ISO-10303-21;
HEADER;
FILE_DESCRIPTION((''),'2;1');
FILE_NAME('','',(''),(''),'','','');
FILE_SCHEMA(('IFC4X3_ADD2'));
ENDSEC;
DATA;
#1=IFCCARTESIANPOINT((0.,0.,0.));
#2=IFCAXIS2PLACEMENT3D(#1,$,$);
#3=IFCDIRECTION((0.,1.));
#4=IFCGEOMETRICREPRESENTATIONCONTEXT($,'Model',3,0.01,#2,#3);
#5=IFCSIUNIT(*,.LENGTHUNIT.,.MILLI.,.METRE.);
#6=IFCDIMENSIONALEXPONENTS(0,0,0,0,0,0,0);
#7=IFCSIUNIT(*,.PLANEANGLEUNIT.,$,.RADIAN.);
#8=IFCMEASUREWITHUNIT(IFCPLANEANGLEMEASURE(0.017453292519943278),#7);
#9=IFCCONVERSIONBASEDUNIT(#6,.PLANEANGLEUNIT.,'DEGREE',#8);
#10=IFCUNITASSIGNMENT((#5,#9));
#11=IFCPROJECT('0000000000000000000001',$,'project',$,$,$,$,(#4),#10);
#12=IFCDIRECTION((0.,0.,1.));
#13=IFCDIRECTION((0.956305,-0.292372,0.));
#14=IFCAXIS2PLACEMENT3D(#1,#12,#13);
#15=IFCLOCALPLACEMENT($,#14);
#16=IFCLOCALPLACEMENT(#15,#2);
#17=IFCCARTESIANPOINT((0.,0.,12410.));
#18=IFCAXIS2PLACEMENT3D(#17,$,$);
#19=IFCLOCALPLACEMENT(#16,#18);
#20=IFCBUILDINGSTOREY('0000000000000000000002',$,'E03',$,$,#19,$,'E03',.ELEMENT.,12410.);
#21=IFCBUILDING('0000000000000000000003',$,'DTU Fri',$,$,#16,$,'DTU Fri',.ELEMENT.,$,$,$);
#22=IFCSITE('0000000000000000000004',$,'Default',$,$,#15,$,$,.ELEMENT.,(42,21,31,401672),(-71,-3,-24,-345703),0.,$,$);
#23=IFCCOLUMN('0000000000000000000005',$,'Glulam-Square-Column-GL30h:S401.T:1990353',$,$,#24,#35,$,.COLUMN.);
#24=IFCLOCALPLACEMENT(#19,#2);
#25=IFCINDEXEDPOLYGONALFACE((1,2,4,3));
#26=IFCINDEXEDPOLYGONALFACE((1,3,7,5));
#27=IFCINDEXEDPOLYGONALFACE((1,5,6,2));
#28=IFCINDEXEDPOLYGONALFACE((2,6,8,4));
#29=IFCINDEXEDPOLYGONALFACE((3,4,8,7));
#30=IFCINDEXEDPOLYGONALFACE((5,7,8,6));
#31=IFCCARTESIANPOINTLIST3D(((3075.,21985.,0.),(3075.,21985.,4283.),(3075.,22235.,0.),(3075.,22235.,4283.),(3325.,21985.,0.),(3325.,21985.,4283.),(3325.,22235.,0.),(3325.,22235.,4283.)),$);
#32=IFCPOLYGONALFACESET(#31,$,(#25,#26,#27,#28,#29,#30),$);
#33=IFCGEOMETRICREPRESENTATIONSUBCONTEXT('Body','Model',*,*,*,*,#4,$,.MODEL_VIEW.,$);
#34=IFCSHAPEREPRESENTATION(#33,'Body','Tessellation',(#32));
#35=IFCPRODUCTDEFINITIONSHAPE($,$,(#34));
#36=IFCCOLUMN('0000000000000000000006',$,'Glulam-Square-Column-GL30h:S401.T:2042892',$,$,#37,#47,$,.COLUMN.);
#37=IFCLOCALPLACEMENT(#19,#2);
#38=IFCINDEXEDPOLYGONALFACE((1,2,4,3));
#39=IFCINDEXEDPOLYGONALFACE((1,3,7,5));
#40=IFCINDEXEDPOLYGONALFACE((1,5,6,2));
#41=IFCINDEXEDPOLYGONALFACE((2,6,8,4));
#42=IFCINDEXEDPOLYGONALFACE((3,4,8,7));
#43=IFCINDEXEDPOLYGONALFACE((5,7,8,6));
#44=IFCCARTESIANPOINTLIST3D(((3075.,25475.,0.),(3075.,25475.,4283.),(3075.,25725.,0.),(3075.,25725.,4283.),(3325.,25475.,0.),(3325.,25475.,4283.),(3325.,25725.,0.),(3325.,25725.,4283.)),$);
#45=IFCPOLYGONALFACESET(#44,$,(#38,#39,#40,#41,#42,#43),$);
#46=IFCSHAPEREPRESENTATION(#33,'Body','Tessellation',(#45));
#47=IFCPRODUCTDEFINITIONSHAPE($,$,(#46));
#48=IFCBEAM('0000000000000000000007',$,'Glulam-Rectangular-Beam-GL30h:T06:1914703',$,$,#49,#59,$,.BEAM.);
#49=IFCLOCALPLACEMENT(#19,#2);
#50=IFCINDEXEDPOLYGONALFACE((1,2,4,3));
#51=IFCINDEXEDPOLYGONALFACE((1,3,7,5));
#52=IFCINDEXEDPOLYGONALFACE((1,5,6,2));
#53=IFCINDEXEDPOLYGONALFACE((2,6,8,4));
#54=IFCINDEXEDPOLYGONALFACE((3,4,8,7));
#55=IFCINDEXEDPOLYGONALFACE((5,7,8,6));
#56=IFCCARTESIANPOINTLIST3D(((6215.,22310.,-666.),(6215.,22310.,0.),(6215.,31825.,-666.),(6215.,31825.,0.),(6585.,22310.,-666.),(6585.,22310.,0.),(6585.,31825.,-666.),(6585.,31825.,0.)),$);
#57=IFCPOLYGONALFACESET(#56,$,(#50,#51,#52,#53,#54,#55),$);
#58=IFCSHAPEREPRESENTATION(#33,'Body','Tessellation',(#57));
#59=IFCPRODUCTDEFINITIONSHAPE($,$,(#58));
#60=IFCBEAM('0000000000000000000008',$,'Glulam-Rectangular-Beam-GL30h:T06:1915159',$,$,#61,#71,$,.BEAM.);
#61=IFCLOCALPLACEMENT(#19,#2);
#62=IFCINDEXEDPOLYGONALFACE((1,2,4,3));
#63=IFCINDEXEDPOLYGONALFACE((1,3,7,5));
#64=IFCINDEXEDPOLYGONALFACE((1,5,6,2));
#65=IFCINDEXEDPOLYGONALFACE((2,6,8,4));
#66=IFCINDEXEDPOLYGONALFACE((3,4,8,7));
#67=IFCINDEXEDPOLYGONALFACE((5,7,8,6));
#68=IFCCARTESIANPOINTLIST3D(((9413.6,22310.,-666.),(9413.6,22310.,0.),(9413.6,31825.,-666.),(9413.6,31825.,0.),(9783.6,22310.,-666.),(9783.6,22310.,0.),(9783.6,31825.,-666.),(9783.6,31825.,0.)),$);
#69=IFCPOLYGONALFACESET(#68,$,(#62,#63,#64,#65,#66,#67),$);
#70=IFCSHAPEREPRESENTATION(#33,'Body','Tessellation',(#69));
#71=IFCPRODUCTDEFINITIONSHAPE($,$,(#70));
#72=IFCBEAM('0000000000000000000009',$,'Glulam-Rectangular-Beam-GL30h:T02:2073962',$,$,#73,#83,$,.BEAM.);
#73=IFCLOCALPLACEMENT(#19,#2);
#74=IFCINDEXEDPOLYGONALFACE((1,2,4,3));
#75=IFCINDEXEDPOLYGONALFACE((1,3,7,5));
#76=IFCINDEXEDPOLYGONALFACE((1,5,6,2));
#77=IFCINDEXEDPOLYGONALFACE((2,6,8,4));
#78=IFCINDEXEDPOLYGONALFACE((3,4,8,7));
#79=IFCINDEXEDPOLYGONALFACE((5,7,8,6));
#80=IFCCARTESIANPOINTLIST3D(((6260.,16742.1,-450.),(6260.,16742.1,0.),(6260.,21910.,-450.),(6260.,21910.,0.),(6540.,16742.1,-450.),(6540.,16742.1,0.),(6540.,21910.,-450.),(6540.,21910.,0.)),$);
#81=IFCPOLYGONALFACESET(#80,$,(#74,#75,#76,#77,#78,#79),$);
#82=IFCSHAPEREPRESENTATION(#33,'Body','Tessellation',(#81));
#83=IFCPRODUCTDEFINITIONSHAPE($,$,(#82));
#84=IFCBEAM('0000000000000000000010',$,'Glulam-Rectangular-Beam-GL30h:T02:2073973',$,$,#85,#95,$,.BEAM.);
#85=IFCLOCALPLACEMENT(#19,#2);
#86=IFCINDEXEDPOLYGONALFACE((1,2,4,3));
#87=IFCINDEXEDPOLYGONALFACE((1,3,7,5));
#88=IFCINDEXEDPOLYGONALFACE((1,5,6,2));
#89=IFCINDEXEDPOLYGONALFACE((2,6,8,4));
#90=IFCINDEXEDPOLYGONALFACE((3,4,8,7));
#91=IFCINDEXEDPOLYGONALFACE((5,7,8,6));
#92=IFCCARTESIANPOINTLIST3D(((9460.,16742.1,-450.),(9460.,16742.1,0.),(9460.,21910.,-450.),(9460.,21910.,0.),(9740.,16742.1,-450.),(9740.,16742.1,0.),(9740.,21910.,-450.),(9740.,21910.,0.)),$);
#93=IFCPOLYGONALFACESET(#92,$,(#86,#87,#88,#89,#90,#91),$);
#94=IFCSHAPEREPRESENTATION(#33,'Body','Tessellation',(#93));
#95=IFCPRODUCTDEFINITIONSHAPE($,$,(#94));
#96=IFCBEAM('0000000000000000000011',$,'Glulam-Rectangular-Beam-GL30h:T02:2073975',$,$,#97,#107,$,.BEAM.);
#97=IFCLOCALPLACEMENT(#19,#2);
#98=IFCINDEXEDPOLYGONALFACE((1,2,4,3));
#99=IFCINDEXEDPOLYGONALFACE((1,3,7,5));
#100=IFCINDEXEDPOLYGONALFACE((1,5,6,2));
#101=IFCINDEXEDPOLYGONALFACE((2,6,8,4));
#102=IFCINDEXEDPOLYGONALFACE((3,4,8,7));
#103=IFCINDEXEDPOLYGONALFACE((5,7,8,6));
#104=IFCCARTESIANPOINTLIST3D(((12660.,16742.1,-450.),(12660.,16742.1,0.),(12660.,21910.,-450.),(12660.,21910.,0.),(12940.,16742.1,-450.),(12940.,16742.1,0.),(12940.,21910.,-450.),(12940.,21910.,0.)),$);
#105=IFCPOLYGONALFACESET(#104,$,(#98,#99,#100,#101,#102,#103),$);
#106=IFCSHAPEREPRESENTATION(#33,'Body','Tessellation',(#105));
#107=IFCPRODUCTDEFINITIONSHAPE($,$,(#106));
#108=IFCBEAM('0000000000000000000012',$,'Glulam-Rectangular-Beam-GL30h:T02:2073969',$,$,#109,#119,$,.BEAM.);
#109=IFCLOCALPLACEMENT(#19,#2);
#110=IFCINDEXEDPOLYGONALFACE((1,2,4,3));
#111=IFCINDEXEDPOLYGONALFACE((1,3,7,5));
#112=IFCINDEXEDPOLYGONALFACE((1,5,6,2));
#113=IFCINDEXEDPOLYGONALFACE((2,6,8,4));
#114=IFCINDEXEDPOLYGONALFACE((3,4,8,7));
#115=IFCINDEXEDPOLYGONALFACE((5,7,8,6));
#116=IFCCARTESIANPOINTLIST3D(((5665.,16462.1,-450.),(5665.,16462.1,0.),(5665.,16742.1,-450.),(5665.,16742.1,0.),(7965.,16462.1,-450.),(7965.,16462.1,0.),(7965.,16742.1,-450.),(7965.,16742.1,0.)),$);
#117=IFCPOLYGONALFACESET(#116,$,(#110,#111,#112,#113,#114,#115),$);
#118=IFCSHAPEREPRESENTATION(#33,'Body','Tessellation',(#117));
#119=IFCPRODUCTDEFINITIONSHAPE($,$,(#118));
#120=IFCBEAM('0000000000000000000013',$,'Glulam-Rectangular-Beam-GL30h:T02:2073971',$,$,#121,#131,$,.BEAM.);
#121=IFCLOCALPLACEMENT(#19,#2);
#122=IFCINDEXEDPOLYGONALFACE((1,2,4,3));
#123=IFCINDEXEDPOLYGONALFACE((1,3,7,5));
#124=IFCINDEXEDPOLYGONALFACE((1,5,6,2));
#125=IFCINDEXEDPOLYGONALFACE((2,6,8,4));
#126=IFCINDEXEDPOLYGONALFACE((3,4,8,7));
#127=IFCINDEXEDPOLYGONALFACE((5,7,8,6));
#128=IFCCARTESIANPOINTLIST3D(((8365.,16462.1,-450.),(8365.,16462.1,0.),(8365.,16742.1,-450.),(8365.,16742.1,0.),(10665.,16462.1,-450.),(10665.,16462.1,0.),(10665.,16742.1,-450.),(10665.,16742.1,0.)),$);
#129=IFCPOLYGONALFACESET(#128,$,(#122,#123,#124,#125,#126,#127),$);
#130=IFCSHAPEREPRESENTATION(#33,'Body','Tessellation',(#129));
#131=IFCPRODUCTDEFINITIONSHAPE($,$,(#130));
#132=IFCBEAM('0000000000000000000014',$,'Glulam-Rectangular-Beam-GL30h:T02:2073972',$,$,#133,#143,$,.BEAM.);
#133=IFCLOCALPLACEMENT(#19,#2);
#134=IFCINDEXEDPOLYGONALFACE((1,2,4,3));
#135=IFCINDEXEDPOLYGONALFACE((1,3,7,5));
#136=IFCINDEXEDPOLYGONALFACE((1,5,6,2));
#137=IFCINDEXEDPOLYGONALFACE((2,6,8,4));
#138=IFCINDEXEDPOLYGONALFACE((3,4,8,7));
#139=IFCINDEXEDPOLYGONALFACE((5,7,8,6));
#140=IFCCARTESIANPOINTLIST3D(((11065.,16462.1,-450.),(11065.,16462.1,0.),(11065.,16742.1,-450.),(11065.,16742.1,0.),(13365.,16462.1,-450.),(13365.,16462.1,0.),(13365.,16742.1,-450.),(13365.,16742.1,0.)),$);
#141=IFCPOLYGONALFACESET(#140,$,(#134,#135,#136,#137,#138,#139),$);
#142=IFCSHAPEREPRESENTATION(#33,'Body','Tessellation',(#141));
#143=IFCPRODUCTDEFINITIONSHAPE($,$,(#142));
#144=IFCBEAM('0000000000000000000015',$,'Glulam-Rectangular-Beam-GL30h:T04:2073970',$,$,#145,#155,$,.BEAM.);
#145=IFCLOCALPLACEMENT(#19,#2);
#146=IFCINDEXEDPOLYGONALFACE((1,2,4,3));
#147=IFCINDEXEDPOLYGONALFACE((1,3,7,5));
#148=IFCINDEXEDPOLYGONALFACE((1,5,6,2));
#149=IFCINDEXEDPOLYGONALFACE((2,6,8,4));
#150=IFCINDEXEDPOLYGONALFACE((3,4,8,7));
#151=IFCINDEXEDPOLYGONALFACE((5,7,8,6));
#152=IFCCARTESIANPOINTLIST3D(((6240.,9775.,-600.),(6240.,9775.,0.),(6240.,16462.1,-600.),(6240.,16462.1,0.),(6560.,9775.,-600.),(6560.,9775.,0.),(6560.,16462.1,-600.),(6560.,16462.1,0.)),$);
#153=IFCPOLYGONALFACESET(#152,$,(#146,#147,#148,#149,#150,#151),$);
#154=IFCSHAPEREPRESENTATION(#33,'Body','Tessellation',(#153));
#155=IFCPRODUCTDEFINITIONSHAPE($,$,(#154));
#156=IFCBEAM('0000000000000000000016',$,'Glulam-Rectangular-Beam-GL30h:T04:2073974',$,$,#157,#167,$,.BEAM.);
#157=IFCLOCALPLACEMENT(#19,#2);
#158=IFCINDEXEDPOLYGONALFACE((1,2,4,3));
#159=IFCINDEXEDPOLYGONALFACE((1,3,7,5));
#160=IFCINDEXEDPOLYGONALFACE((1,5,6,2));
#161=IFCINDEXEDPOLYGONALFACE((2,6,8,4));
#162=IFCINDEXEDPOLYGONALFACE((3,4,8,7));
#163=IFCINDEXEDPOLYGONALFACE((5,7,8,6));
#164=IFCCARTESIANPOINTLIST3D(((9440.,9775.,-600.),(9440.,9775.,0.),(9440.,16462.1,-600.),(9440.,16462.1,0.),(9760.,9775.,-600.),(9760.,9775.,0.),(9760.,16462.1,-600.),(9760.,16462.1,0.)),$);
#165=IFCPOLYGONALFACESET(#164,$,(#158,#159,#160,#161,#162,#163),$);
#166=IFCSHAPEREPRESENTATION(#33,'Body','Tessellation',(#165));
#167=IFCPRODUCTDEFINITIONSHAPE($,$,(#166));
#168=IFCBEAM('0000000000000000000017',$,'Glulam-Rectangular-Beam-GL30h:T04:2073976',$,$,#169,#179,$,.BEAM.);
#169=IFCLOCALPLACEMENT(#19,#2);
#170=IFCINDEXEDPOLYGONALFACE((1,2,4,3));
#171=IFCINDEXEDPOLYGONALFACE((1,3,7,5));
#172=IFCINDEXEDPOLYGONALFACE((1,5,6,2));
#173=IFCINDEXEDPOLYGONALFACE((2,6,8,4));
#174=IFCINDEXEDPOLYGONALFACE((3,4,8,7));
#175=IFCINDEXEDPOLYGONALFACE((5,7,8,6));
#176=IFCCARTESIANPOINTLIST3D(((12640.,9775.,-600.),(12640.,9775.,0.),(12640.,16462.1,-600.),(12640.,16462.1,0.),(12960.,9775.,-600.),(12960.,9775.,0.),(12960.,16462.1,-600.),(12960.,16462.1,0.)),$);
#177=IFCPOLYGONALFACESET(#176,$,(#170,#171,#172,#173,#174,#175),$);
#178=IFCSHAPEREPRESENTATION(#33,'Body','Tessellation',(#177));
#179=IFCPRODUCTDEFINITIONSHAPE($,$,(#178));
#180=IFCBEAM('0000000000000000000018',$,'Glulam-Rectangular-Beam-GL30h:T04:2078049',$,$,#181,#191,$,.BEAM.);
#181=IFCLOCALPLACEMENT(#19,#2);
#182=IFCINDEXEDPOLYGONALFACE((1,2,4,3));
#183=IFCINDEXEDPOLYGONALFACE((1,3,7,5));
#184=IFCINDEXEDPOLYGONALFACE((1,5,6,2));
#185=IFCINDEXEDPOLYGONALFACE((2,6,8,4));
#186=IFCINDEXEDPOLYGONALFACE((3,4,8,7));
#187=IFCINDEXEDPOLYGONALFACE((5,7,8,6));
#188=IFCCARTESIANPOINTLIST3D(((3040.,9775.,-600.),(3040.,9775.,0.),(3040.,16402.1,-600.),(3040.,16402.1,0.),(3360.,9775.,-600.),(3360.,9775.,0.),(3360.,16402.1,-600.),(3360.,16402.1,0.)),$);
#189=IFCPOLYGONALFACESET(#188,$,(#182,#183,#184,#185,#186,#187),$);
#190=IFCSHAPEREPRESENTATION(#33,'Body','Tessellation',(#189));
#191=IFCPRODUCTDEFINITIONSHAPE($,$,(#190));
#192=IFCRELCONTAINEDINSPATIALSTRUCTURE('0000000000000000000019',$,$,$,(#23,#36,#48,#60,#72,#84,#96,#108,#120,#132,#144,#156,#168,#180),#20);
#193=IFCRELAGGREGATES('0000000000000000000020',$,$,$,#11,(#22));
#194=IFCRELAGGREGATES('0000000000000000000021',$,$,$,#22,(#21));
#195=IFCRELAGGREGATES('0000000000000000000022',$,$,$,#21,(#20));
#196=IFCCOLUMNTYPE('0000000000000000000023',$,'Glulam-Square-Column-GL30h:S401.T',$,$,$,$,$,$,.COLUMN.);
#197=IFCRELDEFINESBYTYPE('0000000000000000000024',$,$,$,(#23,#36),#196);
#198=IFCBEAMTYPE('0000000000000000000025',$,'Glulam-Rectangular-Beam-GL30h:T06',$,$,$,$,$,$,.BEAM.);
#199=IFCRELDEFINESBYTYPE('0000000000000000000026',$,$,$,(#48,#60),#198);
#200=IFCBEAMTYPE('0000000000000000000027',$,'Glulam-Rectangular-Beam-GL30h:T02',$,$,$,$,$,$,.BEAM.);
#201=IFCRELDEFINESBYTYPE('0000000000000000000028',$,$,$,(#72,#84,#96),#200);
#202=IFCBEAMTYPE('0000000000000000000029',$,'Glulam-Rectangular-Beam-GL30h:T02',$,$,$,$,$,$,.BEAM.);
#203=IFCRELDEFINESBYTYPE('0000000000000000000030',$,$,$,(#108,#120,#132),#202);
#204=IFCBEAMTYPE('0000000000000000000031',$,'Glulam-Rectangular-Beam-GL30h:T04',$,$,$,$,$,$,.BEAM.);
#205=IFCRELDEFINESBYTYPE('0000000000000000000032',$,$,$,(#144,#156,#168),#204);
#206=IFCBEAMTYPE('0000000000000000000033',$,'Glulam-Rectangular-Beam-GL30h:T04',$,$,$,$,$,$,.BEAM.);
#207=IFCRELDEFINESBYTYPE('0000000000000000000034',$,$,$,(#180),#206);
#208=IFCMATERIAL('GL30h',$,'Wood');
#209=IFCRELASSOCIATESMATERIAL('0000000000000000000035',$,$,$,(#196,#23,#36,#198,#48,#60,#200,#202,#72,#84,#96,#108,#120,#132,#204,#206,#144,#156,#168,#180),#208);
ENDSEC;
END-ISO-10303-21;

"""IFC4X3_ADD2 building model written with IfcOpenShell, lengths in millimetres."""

from ifc_helpers import new_model, entity, si_unit, converted_unit, direction, frame, origin, origin_2d_with_axis, place, context, subcontext, project, spatial, rectangle, extrude, source, transform, mapped, material, material_profile, profile_set, profile_usage, type_object, type_shapes, element, save


model = new_model("IFC4X3_ADD2")

# Units and contexts
model_context = context("Model", 3, precision=0.01, world=origin(), true_north=direction((0.0, 1.0)))
body_context = subcontext(model_context, "Body", "Model", "MODEL_VIEW")
ifc_project = project(units=[si_unit("LENGTHUNIT", "METRE", prefix="MILLI"), converted_unit("PLANEANGLEUNIT", "DEGREE", entity("IfcPlaneAngleMeasure", 0.017453292519943278), si_unit("PLANEANGLEUNIT", "RADIAN"), dimensions=[0, 0, 0, 0, 0, 0, 0])], contexts=[model_context])

# Site, building, storey
site_placement = place(None, frame((0.0, 0.0, 0.0), z_axis=(0.0, 0.0, 1.0), x_axis=(0.956305, -0.292372, 0.0)))
site = spatial("IfcSite", under=ifc_project, at=site_placement, Name="Default", CompositionType="ELEMENT", RefLatitude=(42, 21, 31, 401672), RefLongitude=(-71, -3, -24, -345703), RefElevation=0.0)
building_placement = place(site_placement, origin())
building = spatial("IfcBuilding", under=site, at=building_placement, Name="DTU Fri", LongName="DTU Fri", CompositionType="ELEMENT")
storey_placement = place(building_placement, frame((0.0, 0.0, 12410.0)))
storey = spatial("IfcBuildingStorey", under=building, at=storey_placement, Name="E03", LongName="E03", CompositionType="ELEMENT", Elevation=12410.0)

# Columns
ifc_material = material(Name="GL30h", Category="Wood")
ifc_material_profile_1 = material_profile(ifc_material, rectangle(XDim=250.0, YDim=250.0, at=origin_2d_with_axis()), Name="S401.T")
ifc_profile_set_1 = profile_set([ifc_material_profile_1], Name="S401.T")
ifc_profile_usage_1 = profile_usage(ifc_profile_set_1)
column_type = type_object("IfcColumnType", Name="Glulam-Square-Column-GL30h:S401.T", PredefinedType="COLUMN", material=ifc_profile_set_1)
shared_shape_1 = source(origin(), body_context, "Body", "SweptSolid", [
    extrude(rectangle(XDim=250.0, YDim=250.0, at=origin_2d_with_axis()), frame((0.0, 0.0, 12410.0), z_axis=(0.0, 0.0, 1.0), x_axis=(0.0, 1.0, 0.0)), (0.0, 0.0, 1.0), 4283.0),
])
type_shapes(column_type, [shared_shape_1])
for number, where, name in (
    (1, (3200.0, 22110.0, -12410.0), "Glulam-Square-Column-GL30h:S401.T:1990353"),
    (2, (3200.0, 25600.0, -12410.0), "Glulam-Square-Column-GL30h:S401.T:2042892"),
):
    element("IfcColumn", number, at=place(storey_placement, frame(where)), inside=storey, type_object=column_type, material=ifc_profile_usage_1, Name=name, PredefinedType="COLUMN", context=body_context, shape_type="MappedRepresentation", body=[
        mapped(shared_shape_1, transform((0.0, 0.0, 0.0), scale=1.0)),
    ])

# Beams
ifc_material_profile_2 = material_profile(ifc_material, rectangle(XDim=666.0, YDim=370.0, at=origin_2d_with_axis()), Name="T06")
ifc_profile_set_2 = profile_set([ifc_material_profile_2], Name="T06")
ifc_profile_usage_2 = profile_usage(ifc_profile_set_2, cardinal=8)
beam_type_1 = type_object("IfcBeamType", Name="Glulam-Rectangular-Beam-GL30h:T06", PredefinedType="BEAM", material=ifc_profile_set_2)
shared_shape_2 = source(origin(), body_context, "Body", "SweptSolid", [
    extrude(rectangle(XDim=666.0, YDim=370.0, at=origin_2d_with_axis()), frame((-4770.0, 0.0, 0.0), z_axis=(1.0, 0.0, 0.0), x_axis=(0.0, 0.0, -1.0)), (0.0, 0.0, 1.0), 9515.0),
])
type_shapes(beam_type_1, [shared_shape_2])
for number, where, z_axis, x_axis, name in (
    (3, (6400.0, 27055.0, -333.0), (0.0, 0.0, 1.0), (0.0, -1.0, 0.0), "Glulam-Rectangular-Beam-GL30h:T06:1914703"),
    (4, (9598.6, 27055.0, -333.0), (0.0, 0.0, 1.0), (0.0, -1.0, 0.0), "Glulam-Rectangular-Beam-GL30h:T06:1915159"),
):
    element("IfcBeam", number, at=place(storey_placement, frame(where, z_axis=z_axis, x_axis=x_axis)), inside=storey, type_object=beam_type_1, material=ifc_profile_usage_2, Name=name, PredefinedType="BEAM", context=body_context, shape_type="MappedRepresentation", body=[
        mapped(shared_shape_2, transform((0.0, 0.0, 0.0), scale=1.0)),
    ])
ifc_material_profile_3 = material_profile(ifc_material, rectangle(XDim=450.0, YDim=280.0, at=origin_2d_with_axis()), Name="T02")
ifc_profile_set_3 = profile_set([ifc_material_profile_3], Name="T02")
ifc_profile_usage_3 = profile_usage(ifc_profile_set_3, cardinal=8)
beam_type_2 = type_object("IfcBeamType", Name="Glulam-Rectangular-Beam-GL30h:T02", PredefinedType="BEAM", material=ifc_profile_set_3)
shared_shape_3 = source(origin(), body_context, "Body", "SweptSolid", [
    extrude(rectangle(XDim=450.0, YDim=280.0, at=origin_2d_with_axis()), frame((-2614.0, 0.0, 0.0), z_axis=(1.0, 0.0, 0.0), x_axis=(0.0, 0.0, -1.0)), (0.0, 0.0, 1.0), 5167.9),
])
type_shapes(beam_type_2, [shared_shape_3])
for number, where, z_axis, x_axis, name in (
    (5, (6400.0, 19356.0, -225.0), (0.0, 0.0, 1.0), (0.0, 1.0, 0.0), "Glulam-Rectangular-Beam-GL30h:T02:2073962"),
    (6, (9600.0, 19356.0, -225.0), (0.0, 0.0, 1.0), (0.0, 1.0, 0.0), "Glulam-Rectangular-Beam-GL30h:T02:2073973"),
    (7, (12800.0, 19356.0, -225.0), (0.0, 0.0, 1.0), (0.0, 1.0, 0.0), "Glulam-Rectangular-Beam-GL30h:T02:2073975"),
):
    element("IfcBeam", number, at=place(storey_placement, frame(where, z_axis=z_axis, x_axis=x_axis)), inside=storey, type_object=beam_type_2, material=ifc_profile_usage_3, Name=name, PredefinedType="BEAM", context=body_context, shape_type="MappedRepresentation", body=[
        mapped(shared_shape_3, transform((0.0, 0.0, 0.0), scale=1.0)),
    ])
beam_type_3 = type_object("IfcBeamType", Name="Glulam-Rectangular-Beam-GL30h:T02", PredefinedType="BEAM", material=ifc_profile_set_3)
shared_shape_4 = source(origin(), body_context, "Body", "SweptSolid", [
    extrude(rectangle(XDim=450.0, YDim=280.0, at=origin_2d_with_axis()), frame((-1150.0, 0.0, 0.0), z_axis=(1.0, 0.0, 0.0), x_axis=(0.0, 0.0, -1.0)), (0.0, 0.0, 1.0), 2300.0),
])
type_shapes(beam_type_3, [shared_shape_4])
for number, where, z_axis, x_axis, name in (
    (8, (6815.0, 16602.1, -225.0), (0.0, 0.0, 1.0), (-1.0, 0.0, 0.0), "Glulam-Rectangular-Beam-GL30h:T02:2073969"),
    (9, (9515.0, 16602.1, -225.0), (0.0, 0.0, 1.0), (-1.0, 0.0, 0.0), "Glulam-Rectangular-Beam-GL30h:T02:2073971"),
    (10, (12215.0, 16602.1, -225.0), (0.0, 0.0, 1.0), (-1.0, 0.0, 0.0), "Glulam-Rectangular-Beam-GL30h:T02:2073972"),
):
    element("IfcBeam", number, at=place(storey_placement, frame(where, z_axis=z_axis, x_axis=x_axis)), inside=storey, type_object=beam_type_3, material=ifc_profile_usage_3, Name=name, PredefinedType="BEAM", context=body_context, shape_type="MappedRepresentation", body=[
        mapped(shared_shape_4, transform((0.0, 0.0, 0.0), scale=1.0)),
    ])
ifc_material_profile_4 = material_profile(ifc_material, rectangle(XDim=600.0, YDim=320.0, at=origin_2d_with_axis()), Name="T04")
ifc_profile_set_4 = profile_set([ifc_material_profile_4], Name="T04")
ifc_profile_usage_4 = profile_usage(ifc_profile_set_4, cardinal=8)
beam_type_4 = type_object("IfcBeamType", Name="Glulam-Rectangular-Beam-GL30h:T04", PredefinedType="BEAM", material=ifc_profile_set_4)
shared_shape_5 = source(origin(), body_context, "Body", "SweptSolid", [
    extrude(rectangle(XDim=600.0, YDim=320.0, at=origin_2d_with_axis()), frame((-3326.0, 0.0, 0.0), z_axis=(1.0, 0.0, 0.0), x_axis=(0.0, 0.0, -1.0)), (0.0, 0.0, 1.0), 6687.1),
])
type_shapes(beam_type_4, [shared_shape_5])
for number, where, z_axis, x_axis, name in (
    (11, (6400.0, 13101.0, -300.0), (0.0, 0.0, 1.0), (0.0, 1.0, 0.0), "Glulam-Rectangular-Beam-GL30h:T04:2073970"),
    (12, (9600.0, 13101.0, -300.0), (0.0, 0.0, 1.0), (0.0, 1.0, 0.0), "Glulam-Rectangular-Beam-GL30h:T04:2073974"),
    (13, (12800.0, 13101.0, -300.0), (0.0, 0.0, 1.0), (0.0, 1.0, 0.0), "Glulam-Rectangular-Beam-GL30h:T04:2073976"),
):
    element("IfcBeam", number, at=place(storey_placement, frame(where, z_axis=z_axis, x_axis=x_axis)), inside=storey, type_object=beam_type_4, material=ifc_profile_usage_4, Name=name, PredefinedType="BEAM", context=body_context, shape_type="MappedRepresentation", body=[
        mapped(shared_shape_5, transform((0.0, 0.0, 0.0), scale=1.0)),
    ])
beam_type_5 = type_object("IfcBeamType", Name="Glulam-Rectangular-Beam-GL30h:T04", PredefinedType="BEAM", material=ifc_profile_set_4)
shared_shape_6 = source(origin(), body_context, "Body", "SweptSolid", [
    extrude(rectangle(XDim=600.0, YDim=320.0, at=origin_2d_with_axis()), frame((-3326.0, 0.0, 0.0), z_axis=(1.0, 0.0, 0.0), x_axis=(0.0, 0.0, -1.0)), (0.0, 0.0, 1.0), 6627.1),
])
type_shapes(beam_type_5, [shared_shape_6])
beam_1_placement = place(storey_placement, frame((3200.0, 13101.0, -300.0), z_axis=(0.0, 0.0, 1.0), x_axis=(0.0, 1.0, 0.0)))
element("IfcBeam", 14, at=beam_1_placement, inside=storey, type_object=beam_type_5, material=ifc_profile_usage_4, Name="Glulam-Rectangular-Beam-GL30h:T04:2078049", PredefinedType="BEAM", context=body_context, shape_type="MappedRepresentation", body=[
    mapped(shared_shape_6, transform((0.0, 0.0, 0.0), scale=1.0)),
])

save(model, "model.ifc")
